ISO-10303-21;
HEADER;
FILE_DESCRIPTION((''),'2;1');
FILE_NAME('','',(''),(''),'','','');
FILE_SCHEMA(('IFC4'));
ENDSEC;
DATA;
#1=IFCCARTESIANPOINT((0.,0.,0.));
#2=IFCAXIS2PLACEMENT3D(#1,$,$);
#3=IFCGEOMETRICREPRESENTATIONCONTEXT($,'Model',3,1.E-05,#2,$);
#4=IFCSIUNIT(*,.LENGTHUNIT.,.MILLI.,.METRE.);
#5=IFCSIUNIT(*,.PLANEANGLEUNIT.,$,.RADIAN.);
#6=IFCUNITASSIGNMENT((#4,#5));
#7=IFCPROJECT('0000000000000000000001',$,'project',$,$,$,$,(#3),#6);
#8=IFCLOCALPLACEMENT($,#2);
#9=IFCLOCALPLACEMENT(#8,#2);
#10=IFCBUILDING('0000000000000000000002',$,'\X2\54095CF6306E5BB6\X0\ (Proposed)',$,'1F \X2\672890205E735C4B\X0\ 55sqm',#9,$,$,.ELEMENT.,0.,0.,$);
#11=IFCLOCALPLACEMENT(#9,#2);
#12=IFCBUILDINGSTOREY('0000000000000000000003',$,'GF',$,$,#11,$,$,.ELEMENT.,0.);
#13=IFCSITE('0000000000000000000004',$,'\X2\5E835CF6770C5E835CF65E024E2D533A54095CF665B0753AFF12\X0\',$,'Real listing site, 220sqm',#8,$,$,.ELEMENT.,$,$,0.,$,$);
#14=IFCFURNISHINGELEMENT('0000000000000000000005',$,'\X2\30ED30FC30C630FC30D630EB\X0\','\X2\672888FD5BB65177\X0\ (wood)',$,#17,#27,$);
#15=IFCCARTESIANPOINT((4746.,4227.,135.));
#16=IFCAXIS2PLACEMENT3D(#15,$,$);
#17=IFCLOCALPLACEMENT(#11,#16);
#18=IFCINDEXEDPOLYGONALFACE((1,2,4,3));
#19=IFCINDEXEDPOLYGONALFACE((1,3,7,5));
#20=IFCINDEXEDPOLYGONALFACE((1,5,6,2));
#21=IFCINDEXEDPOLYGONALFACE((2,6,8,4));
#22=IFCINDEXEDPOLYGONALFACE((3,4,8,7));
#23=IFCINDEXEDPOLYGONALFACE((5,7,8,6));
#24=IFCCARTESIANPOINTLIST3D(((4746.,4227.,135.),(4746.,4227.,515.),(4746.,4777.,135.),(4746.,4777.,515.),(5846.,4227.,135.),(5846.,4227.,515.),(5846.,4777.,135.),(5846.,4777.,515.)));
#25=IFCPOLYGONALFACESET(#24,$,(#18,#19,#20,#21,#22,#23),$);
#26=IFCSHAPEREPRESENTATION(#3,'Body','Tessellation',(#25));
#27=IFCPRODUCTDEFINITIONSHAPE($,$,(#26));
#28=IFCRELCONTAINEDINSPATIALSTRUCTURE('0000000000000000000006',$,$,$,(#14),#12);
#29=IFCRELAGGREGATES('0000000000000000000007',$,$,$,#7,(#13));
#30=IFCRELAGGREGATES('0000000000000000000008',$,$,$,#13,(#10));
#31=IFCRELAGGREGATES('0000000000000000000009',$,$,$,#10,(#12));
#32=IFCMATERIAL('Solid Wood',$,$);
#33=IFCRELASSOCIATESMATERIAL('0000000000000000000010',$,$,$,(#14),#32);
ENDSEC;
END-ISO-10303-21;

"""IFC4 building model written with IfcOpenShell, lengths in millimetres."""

from ifc_helpers import new_model, si_unit, frame, frame_2d, origin, place, context, project, spatial, rectangle, extrude, material, element, save


model = new_model("IFC4")

# Units and contexts
model_context = context("Model", 3, precision=1e-05, world=origin())
ifc_project = project(units=[si_unit("LENGTHUNIT", "METRE", prefix="MILLI"), si_unit("PLANEANGLEUNIT", "RADIAN")], contexts=[model_context])

# Site, building, storey
site_placement = place(None, origin())
site = spatial("IfcSite", under=ifc_project, at=site_placement, Name="広島県広島市中区吉島新町２", ObjectType="Real listing site, 220sqm", CompositionType="ELEMENT", RefElevation=0.0)
building_placement = place(site_placement, origin())
building = spatial("IfcBuilding", under=site, at=building_placement, Name="吉島の家 (Proposed)", ObjectType="1F 木造平屋 55sqm", CompositionType="ELEMENT", ElevationOfRefHeight=0.0, ElevationOfTerrain=0.0)
storey_placement = place(building_placement, origin())
storey = spatial("IfcBuildingStorey", under=building, at=storey_placement, Name="GF", CompositionType="ELEMENT", Elevation=0.0)

# Shared definitions
ifc_material_1 = material(Name="Solid Wood")

# Furnishing element
furnishing_1_placement = place(storey_placement, frame((4746.0, 4227.0, 135.0)))
element("IfcFurnishingElement", 1, at=furnishing_1_placement, inside=storey, material=ifc_material_1, Name="ローテーブル", Description="木製家具 (wood)", context=model_context, shape_type="SweptSolid", body=[
    extrude(rectangle(XDim=1100.0, YDim=550.0, at=frame_2d((550.0, 275.0))), frame((4746.0, 4227.0, 135.0)), (0.0, 0.0, 1.0), 380.0),
])

save(model, "model.ifc")
